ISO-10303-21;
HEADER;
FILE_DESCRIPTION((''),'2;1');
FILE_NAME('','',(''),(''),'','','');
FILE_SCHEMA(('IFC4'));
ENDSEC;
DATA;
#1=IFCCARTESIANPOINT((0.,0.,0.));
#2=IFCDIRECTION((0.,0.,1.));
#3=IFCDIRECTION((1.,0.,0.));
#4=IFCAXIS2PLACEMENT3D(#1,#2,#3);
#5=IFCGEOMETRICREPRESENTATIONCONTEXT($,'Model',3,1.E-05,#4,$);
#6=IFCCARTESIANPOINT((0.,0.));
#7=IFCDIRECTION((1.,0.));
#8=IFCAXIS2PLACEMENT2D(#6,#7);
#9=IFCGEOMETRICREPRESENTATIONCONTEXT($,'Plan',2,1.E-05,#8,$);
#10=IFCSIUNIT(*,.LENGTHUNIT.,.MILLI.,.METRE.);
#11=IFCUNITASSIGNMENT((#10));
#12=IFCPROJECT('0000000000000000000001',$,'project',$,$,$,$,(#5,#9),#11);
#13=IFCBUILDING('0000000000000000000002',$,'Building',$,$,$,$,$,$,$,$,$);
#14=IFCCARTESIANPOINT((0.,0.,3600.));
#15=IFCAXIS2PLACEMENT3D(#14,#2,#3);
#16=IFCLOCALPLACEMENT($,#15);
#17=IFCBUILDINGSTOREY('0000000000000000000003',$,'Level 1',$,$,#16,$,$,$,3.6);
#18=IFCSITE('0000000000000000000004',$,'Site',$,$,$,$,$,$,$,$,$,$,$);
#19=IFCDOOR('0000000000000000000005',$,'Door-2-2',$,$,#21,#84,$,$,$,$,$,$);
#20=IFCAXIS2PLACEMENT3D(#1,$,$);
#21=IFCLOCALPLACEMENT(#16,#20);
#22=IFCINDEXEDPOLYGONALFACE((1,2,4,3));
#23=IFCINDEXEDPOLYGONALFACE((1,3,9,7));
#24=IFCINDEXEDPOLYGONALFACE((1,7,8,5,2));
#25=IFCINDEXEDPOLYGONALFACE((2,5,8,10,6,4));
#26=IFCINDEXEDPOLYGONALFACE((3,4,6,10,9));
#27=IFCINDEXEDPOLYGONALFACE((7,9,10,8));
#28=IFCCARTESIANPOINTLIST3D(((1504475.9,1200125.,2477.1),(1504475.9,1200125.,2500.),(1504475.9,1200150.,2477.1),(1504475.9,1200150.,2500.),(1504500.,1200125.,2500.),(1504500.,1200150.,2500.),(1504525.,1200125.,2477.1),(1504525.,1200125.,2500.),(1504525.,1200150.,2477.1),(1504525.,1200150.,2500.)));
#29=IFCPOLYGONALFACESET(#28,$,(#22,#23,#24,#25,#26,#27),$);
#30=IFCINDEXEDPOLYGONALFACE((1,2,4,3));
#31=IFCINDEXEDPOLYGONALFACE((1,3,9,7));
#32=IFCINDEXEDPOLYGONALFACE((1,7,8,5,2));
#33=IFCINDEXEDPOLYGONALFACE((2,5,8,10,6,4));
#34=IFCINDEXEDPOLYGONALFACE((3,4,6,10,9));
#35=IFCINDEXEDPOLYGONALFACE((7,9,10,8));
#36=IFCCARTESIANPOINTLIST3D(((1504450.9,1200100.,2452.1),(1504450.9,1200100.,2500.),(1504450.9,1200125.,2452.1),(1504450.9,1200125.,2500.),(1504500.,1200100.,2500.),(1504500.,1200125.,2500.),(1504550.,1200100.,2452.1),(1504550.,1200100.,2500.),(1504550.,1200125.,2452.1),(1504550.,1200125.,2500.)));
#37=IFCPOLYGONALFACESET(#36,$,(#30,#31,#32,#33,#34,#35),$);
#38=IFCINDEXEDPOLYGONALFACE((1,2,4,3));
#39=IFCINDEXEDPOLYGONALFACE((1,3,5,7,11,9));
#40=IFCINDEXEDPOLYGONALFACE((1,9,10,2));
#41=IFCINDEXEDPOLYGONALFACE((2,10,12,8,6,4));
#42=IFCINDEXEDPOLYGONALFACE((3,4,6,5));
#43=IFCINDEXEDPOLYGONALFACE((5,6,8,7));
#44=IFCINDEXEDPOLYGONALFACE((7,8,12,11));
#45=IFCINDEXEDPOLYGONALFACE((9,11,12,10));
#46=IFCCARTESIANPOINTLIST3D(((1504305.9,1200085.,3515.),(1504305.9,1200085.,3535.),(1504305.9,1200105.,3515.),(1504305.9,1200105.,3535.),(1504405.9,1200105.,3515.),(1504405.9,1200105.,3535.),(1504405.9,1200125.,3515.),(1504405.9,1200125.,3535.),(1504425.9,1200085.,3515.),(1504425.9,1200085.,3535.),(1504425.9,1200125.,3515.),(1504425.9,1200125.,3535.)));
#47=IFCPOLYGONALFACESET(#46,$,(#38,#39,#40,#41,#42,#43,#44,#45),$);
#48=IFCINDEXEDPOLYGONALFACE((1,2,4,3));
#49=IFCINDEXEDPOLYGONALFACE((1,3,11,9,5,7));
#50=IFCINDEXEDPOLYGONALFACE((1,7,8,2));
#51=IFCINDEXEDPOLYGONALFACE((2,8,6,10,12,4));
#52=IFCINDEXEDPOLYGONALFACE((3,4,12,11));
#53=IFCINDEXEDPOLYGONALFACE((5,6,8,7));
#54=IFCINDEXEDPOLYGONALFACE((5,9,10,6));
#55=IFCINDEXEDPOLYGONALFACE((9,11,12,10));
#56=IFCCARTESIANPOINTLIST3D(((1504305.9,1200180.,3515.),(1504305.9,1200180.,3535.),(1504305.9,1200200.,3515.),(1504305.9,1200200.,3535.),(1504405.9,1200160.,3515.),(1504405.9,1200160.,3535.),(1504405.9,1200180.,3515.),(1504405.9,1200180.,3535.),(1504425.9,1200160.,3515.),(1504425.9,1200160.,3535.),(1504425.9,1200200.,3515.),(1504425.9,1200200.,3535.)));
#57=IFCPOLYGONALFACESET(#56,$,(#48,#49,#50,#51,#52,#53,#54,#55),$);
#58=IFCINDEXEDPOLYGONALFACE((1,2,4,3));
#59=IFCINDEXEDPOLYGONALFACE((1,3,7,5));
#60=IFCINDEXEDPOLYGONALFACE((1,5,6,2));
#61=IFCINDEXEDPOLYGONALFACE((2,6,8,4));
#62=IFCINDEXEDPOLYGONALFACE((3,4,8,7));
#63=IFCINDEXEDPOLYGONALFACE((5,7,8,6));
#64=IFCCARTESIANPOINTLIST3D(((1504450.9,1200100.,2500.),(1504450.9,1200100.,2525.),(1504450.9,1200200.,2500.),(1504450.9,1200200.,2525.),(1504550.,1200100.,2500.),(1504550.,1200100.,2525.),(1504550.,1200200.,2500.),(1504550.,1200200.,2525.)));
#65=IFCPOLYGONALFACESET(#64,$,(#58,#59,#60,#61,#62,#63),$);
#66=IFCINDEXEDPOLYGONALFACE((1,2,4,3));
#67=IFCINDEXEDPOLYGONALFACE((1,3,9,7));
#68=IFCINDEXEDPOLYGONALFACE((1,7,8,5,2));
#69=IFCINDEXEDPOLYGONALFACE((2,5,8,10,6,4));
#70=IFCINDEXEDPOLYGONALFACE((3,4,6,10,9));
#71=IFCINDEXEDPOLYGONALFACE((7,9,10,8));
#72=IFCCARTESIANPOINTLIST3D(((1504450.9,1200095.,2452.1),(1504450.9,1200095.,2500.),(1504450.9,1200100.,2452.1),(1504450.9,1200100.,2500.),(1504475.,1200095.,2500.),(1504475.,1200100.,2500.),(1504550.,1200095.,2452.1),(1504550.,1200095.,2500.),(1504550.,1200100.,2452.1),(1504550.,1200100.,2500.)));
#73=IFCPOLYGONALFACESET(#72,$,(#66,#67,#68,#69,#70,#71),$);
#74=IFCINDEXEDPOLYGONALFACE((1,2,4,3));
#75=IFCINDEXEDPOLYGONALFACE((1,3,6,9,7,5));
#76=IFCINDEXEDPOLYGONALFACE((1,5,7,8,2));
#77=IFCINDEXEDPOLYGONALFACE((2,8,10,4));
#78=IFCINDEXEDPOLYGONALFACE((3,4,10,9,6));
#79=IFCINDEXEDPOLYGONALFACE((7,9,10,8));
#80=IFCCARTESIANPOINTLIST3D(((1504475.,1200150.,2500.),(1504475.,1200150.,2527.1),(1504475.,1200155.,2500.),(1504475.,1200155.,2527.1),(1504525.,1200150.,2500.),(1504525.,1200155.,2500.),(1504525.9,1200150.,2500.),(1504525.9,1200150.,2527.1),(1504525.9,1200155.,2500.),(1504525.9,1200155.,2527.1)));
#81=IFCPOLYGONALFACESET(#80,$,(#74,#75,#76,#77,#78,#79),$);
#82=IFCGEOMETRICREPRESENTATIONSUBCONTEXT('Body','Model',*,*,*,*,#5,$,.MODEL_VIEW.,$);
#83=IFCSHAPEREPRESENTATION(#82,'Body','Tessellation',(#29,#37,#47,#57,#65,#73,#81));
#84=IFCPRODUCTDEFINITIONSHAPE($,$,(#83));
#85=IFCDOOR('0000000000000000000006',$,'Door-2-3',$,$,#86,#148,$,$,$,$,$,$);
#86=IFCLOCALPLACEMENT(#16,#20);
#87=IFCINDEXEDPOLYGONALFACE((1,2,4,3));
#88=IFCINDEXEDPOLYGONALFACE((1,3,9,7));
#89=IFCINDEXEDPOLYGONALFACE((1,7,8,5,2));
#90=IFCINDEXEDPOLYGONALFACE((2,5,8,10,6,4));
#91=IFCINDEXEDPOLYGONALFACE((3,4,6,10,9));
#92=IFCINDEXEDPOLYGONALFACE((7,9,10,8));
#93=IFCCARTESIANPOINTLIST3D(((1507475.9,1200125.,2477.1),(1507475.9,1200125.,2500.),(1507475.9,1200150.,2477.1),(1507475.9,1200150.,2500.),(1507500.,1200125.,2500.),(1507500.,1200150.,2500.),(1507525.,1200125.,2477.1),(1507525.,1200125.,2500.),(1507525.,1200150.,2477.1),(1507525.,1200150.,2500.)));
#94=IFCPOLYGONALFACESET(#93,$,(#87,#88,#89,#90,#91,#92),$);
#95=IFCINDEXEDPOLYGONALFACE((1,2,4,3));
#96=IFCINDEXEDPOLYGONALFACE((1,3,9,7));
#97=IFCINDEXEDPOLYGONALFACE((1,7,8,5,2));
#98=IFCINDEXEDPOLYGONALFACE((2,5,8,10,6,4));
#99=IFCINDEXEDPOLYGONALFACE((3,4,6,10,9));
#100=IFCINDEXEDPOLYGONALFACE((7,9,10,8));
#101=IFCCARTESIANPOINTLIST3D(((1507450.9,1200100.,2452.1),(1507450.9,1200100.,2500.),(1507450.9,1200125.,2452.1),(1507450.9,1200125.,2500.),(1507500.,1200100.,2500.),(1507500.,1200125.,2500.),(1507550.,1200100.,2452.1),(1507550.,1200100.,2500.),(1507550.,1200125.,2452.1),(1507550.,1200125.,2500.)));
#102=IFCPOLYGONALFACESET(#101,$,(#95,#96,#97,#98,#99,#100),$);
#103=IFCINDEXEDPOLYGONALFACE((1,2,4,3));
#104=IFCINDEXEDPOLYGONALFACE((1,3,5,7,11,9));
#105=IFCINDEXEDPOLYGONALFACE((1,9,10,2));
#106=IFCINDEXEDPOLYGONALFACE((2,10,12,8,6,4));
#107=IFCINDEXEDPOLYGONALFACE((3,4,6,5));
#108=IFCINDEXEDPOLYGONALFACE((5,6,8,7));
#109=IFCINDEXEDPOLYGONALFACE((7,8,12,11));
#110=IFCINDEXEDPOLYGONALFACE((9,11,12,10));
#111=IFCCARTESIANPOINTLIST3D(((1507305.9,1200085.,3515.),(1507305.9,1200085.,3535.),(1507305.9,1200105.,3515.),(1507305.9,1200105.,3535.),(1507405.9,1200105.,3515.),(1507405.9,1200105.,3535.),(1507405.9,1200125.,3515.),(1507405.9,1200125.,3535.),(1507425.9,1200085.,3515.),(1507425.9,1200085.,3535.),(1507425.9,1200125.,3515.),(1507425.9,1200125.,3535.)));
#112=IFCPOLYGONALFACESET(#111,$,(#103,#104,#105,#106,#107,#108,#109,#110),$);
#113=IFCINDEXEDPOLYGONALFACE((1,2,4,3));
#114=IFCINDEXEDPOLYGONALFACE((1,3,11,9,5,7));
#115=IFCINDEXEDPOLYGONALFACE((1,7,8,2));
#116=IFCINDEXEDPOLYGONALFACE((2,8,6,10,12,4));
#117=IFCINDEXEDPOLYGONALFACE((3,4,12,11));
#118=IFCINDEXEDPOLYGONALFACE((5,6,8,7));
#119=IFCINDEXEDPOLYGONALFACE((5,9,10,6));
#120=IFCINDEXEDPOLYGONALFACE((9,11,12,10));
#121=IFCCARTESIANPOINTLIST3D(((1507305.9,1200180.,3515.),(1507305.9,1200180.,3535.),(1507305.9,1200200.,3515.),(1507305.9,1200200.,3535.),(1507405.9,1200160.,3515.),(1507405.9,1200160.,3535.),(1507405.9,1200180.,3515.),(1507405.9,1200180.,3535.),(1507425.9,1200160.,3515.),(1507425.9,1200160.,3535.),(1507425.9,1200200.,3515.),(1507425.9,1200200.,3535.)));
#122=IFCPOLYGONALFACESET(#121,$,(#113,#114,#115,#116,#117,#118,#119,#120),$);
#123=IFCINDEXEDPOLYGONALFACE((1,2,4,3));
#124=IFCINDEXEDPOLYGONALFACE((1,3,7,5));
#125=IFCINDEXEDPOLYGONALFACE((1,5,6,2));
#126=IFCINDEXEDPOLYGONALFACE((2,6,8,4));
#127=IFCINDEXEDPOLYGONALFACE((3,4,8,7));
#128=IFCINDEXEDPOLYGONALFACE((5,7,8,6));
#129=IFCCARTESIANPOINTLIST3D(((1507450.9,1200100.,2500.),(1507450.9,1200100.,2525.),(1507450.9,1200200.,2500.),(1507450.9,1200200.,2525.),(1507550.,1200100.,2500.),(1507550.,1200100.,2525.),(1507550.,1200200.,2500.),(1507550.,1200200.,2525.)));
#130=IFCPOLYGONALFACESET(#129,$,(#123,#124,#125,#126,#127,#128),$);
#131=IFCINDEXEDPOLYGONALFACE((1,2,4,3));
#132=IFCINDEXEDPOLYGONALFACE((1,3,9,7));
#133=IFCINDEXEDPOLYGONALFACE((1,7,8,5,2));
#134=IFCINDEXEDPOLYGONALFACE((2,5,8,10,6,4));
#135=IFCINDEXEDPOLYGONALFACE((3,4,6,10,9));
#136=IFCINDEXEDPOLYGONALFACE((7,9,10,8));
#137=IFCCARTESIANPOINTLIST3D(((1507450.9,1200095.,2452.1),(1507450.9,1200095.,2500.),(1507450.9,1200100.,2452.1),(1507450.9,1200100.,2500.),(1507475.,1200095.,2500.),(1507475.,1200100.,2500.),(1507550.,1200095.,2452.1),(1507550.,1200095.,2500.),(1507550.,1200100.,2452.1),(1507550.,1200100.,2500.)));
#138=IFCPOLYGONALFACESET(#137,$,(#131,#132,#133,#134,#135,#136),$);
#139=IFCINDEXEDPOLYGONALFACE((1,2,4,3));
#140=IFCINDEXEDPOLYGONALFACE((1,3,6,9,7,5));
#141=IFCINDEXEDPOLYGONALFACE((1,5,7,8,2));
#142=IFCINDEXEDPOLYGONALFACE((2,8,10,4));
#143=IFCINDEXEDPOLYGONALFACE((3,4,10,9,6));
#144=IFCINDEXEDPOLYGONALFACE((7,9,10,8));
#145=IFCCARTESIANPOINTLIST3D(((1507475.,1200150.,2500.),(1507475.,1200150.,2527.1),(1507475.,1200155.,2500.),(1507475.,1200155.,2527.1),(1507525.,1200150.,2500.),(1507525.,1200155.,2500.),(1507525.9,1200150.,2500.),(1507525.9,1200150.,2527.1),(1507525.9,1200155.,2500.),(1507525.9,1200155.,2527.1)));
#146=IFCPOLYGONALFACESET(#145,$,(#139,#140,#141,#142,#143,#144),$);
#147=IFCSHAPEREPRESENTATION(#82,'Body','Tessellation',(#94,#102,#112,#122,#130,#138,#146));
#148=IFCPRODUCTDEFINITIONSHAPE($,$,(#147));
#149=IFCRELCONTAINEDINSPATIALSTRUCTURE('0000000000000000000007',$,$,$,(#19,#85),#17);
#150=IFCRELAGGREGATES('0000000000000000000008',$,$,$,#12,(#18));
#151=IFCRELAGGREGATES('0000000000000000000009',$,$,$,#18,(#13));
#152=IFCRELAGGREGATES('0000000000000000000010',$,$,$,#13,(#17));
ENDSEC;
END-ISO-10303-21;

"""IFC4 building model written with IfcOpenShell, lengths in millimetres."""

from ifc_helpers import new_model, si_unit, frame, origin_with_axes, origin_2d_with_axis, place, context, subcontext, project, spatial, line, indexed_curve, outline, extrude, element, save


model = new_model("IFC4")

# Units and contexts
model_context = context("Model", 3, precision=1e-05, world=origin_with_axes())
plan_context = context("Plan", 2, precision=1e-05, world=origin_2d_with_axis())
body_context = subcontext(model_context, "Body", "Model", "MODEL_VIEW")
ifc_project = project(units=[si_unit("LENGTHUNIT", "METRE", prefix="MILLI")], contexts=[model_context, plan_context])

# Site, building, storey
site = spatial("IfcSite", under=ifc_project, Name="Site")
building = spatial("IfcBuilding", under=site, Name="Building")
storey_placement = place(None, frame((0.0, 0.0, 3600.0), z_axis=(0.0, 0.0, 1.0), x_axis=(1.0, 0.0, 0.0)))
storey = spatial("IfcBuildingStorey", under=building, at=storey_placement, Name="Level 1", Elevation=3.6)

# Doors
door_1_placement = place(storey_placement, frame((1504500.0, 1200100.0, 2500.0), z_axis=(0.0, 0.0, 1.0), x_axis=(1.0, 0.0, 0.0)))
element("IfcDoor", 1, at=door_1_placement, inside=storey, Name="Door-2-2", context=body_context, shape_type="SweptSolid", body=[
    extrude(outline(indexed_curve([(0.0, 0.0), (0.0, 2.1), (0.9, 2.1), (0.9, 0.0), (-24.1, 0.0), (-24.1, -22.9), (25.0, -22.9), (25.0, 0.0)], segments=[line(1, 2, 3, 4, 5, 6, 7, 8, 1)])), frame((0.0, 25.0, 0.0), z_axis=(0.0, -1.0, 0.0), x_axis=(1.0, 0.0, 0.0)), (0.0, 0.0, -1.0), 25.0),
    extrude(outline(indexed_curve([(0.0, 0.0), (0.0, 2.1), (0.9, 2.1), (0.9, 0.0), (-49.1, 0.0), (-49.1, -47.9), (50.0, -47.9), (50.0, 0.0)], segments=[line(1, 2, 3, 4, 5, 6, 7, 8, 1)])), frame((0.0, 0.0, 0.0), z_axis=(0.0, -1.0, 0.0), x_axis=(1.0, 0.0, 0.0)), (0.0, 0.0, -1.0), 25.0),
    extrude(outline(indexed_curve([(0.0, 0.0), (-49.1, 0.0), (-49.1, 35.0), (0.0, 35.0)], segments=[line(1, 2, 3, 4, 1)])), frame((25.0, 25.0, 25.0), z_axis=(0.0, 0.0, 1.0), x_axis=(1.0, 0.0, 0.0)), (0.0, 0.0, 1.0), -47.9),
    extrude(outline(indexed_curve([(0.0, 0.0), (0.0, -40.0), (-120.0, -40.0), (-120.0, -20.0), (-20.0, -20.0), (-20.0, 0.0)], segments=[line(1, 2, 3, 4, 5, 6, 1)])), frame((-74.1, 25.0, 1015.0), z_axis=(0.0, 0.0, 1.0), x_axis=(1.0, 0.0, 0.0)), (0.0, 0.0, 1.0), 20.0),
    extrude(outline(indexed_curve([(0.0, 0.0), (0.0, 40.0), (-120.0, 40.0), (-120.0, 20.0), (-20.0, 20.0), (-20.0, 0.0)], segments=[line(1, 2, 3, 4, 5, 6, 1)])), frame((-74.1, 60.0, 1015.0), z_axis=(0.0, 0.0, 1.0), x_axis=(1.0, 0.0, 0.0)), (0.0, 0.0, 1.0), 20.0),
    extrude(outline(indexed_curve([(0.0, 0.0), (-99.1, 0.0), (-99.1, 100.0), (0.0, 100.0)], segments=[line(1, 2, 3, 4, 1)])), frame((50.0, 0.0, 0.0), z_axis=(0.0, 0.0, 1.0), x_axis=(1.0, 0.0, 0.0)), (0.0, 0.0, 1.0), 25.0),
    extrude(outline(indexed_curve([(0.0, 0.0), (0.0, 27.1), (50.9, 27.1), (50.9, 0.0), (-24.1, 0.0), (-24.1, -47.9), (75.0, -47.9), (75.0, 0.0)], segments=[line(1, 2, 3, 4, 5, 6, 7, 8, 1)])), frame((-25.0, -5.0, 0.0), z_axis=(0.0, -1.0, 0.0), x_axis=(1.0, 0.0, 0.0)), (0.0, 0.0, -1.0), 5.0),
    extrude(outline(indexed_curve([(0.0, 0.0), (0.0, 27.1), (50.9, 27.1), (50.9, 0.0), (0.9, 0.0), (0.9, -22.9), (50.0, -22.9), (50.0, 0.0)], segments=[line(1, 2, 3, 4, 5, 6, 7, 8, 1)])), frame((-25.0, 50.0, 0.0), z_axis=(0.0, -1.0, 0.0), x_axis=(1.0, 0.0, 0.0)), (0.0, 0.0, -1.0), 5.0),
])
door_2_placement = place(storey_placement, frame((1507500.0, 1200100.0, 2500.0), z_axis=(0.0, 0.0, 1.0), x_axis=(1.0, 0.0, 0.0)))
element("IfcDoor", 2, at=door_2_placement, inside=storey, Name="Door-2-3", context=body_context, shape_type="SweptSolid", body=[
    extrude(outline(indexed_curve([(0.0, 0.0), (0.0, 2.1), (0.9, 2.1), (0.9, 0.0), (-24.1, 0.0), (-24.1, -22.9), (25.0, -22.9), (25.0, 0.0)], segments=[line(1, 2, 3, 4, 5, 6, 7, 8, 1)])), frame((0.0, 25.0, 0.0), z_axis=(0.0, -1.0, 0.0), x_axis=(1.0, 0.0, 0.0)), (0.0, 0.0, -1.0), 25.0),
    extrude(outline(indexed_curve([(0.0, 0.0), (0.0, 2.1), (0.9, 2.1), (0.9, 0.0), (-49.1, 0.0), (-49.1, -47.9), (50.0, -47.9), (50.0, 0.0)], segments=[line(1, 2, 3, 4, 5, 6, 7, 8, 1)])), frame((0.0, 0.0, 0.0), z_axis=(0.0, -1.0, 0.0), x_axis=(1.0, 0.0, 0.0)), (0.0, 0.0, -1.0), 25.0),
    extrude(outline(indexed_curve([(0.0, 0.0), (-49.1, 0.0), (-49.1, 35.0), (0.0, 35.0)], segments=[line(1, 2, 3, 4, 1)])), frame((25.0, 25.0, 25.0), z_axis=(0.0, 0.0, 1.0), x_axis=(1.0, 0.0, 0.0)), (0.0, 0.0, 1.0), -47.9),
    extrude(outline(indexed_curve([(0.0, 0.0), (0.0, -40.0), (-120.0, -40.0), (-120.0, -20.0), (-20.0, -20.0), (-20.0, 0.0)], segments=[line(1, 2, 3, 4, 5, 6, 1)])), frame((-74.1, 25.0, 1015.0), z_axis=(0.0, 0.0, 1.0), x_axis=(1.0, 0.0, 0.0)), (0.0, 0.0, 1.0), 20.0),
    extrude(outline(indexed_curve([(0.0, 0.0), (0.0, 40.0), (-120.0, 40.0), (-120.0, 20.0), (-20.0, 20.0), (-20.0, 0.0)], segments=[line(1, 2, 3, 4, 5, 6, 1)])), frame((-74.1, 60.0, 1015.0), z_axis=(0.0, 0.0, 1.0), x_axis=(1.0, 0.0, 0.0)), (0.0, 0.0, 1.0), 20.0),
    extrude(outline(indexed_curve([(0.0, 0.0), (-99.1, 0.0), (-99.1, 100.0), (0.0, 100.0)], segments=[line(1, 2, 3, 4, 1)])), frame((50.0, 0.0, 0.0), z_axis=(0.0, 0.0, 1.0), x_axis=(1.0, 0.0, 0.0)), (0.0, 0.0, 1.0), 25.0),
    extrude(outline(indexed_curve([(0.0, 0.0), (0.0, 27.1), (50.9, 27.1), (50.9, 0.0), (-24.1, 0.0), (-24.1, -47.9), (75.0, -47.9), (75.0, 0.0)], segments=[line(1, 2, 3, 4, 5, 6, 7, 8, 1)])), frame((-25.0, -5.0, 0.0), z_axis=(0.0, -1.0, 0.0), x_axis=(1.0, 0.0, 0.0)), (0.0, 0.0, -1.0), 5.0),
    extrude(outline(indexed_curve([(0.0, 0.0), (0.0, 27.1), (50.9, 27.1), (50.9, 0.0), (0.9, 0.0), (0.9, -22.9), (50.0, -22.9), (50.0, 0.0)], segments=[line(1, 2, 3, 4, 5, 6, 7, 8, 1)])), frame((-25.0, 50.0, 0.0), z_axis=(0.0, -1.0, 0.0), x_axis=(1.0, 0.0, 0.0)), (0.0, 0.0, -1.0), 5.0),
])

save(model, "model.ifc")
